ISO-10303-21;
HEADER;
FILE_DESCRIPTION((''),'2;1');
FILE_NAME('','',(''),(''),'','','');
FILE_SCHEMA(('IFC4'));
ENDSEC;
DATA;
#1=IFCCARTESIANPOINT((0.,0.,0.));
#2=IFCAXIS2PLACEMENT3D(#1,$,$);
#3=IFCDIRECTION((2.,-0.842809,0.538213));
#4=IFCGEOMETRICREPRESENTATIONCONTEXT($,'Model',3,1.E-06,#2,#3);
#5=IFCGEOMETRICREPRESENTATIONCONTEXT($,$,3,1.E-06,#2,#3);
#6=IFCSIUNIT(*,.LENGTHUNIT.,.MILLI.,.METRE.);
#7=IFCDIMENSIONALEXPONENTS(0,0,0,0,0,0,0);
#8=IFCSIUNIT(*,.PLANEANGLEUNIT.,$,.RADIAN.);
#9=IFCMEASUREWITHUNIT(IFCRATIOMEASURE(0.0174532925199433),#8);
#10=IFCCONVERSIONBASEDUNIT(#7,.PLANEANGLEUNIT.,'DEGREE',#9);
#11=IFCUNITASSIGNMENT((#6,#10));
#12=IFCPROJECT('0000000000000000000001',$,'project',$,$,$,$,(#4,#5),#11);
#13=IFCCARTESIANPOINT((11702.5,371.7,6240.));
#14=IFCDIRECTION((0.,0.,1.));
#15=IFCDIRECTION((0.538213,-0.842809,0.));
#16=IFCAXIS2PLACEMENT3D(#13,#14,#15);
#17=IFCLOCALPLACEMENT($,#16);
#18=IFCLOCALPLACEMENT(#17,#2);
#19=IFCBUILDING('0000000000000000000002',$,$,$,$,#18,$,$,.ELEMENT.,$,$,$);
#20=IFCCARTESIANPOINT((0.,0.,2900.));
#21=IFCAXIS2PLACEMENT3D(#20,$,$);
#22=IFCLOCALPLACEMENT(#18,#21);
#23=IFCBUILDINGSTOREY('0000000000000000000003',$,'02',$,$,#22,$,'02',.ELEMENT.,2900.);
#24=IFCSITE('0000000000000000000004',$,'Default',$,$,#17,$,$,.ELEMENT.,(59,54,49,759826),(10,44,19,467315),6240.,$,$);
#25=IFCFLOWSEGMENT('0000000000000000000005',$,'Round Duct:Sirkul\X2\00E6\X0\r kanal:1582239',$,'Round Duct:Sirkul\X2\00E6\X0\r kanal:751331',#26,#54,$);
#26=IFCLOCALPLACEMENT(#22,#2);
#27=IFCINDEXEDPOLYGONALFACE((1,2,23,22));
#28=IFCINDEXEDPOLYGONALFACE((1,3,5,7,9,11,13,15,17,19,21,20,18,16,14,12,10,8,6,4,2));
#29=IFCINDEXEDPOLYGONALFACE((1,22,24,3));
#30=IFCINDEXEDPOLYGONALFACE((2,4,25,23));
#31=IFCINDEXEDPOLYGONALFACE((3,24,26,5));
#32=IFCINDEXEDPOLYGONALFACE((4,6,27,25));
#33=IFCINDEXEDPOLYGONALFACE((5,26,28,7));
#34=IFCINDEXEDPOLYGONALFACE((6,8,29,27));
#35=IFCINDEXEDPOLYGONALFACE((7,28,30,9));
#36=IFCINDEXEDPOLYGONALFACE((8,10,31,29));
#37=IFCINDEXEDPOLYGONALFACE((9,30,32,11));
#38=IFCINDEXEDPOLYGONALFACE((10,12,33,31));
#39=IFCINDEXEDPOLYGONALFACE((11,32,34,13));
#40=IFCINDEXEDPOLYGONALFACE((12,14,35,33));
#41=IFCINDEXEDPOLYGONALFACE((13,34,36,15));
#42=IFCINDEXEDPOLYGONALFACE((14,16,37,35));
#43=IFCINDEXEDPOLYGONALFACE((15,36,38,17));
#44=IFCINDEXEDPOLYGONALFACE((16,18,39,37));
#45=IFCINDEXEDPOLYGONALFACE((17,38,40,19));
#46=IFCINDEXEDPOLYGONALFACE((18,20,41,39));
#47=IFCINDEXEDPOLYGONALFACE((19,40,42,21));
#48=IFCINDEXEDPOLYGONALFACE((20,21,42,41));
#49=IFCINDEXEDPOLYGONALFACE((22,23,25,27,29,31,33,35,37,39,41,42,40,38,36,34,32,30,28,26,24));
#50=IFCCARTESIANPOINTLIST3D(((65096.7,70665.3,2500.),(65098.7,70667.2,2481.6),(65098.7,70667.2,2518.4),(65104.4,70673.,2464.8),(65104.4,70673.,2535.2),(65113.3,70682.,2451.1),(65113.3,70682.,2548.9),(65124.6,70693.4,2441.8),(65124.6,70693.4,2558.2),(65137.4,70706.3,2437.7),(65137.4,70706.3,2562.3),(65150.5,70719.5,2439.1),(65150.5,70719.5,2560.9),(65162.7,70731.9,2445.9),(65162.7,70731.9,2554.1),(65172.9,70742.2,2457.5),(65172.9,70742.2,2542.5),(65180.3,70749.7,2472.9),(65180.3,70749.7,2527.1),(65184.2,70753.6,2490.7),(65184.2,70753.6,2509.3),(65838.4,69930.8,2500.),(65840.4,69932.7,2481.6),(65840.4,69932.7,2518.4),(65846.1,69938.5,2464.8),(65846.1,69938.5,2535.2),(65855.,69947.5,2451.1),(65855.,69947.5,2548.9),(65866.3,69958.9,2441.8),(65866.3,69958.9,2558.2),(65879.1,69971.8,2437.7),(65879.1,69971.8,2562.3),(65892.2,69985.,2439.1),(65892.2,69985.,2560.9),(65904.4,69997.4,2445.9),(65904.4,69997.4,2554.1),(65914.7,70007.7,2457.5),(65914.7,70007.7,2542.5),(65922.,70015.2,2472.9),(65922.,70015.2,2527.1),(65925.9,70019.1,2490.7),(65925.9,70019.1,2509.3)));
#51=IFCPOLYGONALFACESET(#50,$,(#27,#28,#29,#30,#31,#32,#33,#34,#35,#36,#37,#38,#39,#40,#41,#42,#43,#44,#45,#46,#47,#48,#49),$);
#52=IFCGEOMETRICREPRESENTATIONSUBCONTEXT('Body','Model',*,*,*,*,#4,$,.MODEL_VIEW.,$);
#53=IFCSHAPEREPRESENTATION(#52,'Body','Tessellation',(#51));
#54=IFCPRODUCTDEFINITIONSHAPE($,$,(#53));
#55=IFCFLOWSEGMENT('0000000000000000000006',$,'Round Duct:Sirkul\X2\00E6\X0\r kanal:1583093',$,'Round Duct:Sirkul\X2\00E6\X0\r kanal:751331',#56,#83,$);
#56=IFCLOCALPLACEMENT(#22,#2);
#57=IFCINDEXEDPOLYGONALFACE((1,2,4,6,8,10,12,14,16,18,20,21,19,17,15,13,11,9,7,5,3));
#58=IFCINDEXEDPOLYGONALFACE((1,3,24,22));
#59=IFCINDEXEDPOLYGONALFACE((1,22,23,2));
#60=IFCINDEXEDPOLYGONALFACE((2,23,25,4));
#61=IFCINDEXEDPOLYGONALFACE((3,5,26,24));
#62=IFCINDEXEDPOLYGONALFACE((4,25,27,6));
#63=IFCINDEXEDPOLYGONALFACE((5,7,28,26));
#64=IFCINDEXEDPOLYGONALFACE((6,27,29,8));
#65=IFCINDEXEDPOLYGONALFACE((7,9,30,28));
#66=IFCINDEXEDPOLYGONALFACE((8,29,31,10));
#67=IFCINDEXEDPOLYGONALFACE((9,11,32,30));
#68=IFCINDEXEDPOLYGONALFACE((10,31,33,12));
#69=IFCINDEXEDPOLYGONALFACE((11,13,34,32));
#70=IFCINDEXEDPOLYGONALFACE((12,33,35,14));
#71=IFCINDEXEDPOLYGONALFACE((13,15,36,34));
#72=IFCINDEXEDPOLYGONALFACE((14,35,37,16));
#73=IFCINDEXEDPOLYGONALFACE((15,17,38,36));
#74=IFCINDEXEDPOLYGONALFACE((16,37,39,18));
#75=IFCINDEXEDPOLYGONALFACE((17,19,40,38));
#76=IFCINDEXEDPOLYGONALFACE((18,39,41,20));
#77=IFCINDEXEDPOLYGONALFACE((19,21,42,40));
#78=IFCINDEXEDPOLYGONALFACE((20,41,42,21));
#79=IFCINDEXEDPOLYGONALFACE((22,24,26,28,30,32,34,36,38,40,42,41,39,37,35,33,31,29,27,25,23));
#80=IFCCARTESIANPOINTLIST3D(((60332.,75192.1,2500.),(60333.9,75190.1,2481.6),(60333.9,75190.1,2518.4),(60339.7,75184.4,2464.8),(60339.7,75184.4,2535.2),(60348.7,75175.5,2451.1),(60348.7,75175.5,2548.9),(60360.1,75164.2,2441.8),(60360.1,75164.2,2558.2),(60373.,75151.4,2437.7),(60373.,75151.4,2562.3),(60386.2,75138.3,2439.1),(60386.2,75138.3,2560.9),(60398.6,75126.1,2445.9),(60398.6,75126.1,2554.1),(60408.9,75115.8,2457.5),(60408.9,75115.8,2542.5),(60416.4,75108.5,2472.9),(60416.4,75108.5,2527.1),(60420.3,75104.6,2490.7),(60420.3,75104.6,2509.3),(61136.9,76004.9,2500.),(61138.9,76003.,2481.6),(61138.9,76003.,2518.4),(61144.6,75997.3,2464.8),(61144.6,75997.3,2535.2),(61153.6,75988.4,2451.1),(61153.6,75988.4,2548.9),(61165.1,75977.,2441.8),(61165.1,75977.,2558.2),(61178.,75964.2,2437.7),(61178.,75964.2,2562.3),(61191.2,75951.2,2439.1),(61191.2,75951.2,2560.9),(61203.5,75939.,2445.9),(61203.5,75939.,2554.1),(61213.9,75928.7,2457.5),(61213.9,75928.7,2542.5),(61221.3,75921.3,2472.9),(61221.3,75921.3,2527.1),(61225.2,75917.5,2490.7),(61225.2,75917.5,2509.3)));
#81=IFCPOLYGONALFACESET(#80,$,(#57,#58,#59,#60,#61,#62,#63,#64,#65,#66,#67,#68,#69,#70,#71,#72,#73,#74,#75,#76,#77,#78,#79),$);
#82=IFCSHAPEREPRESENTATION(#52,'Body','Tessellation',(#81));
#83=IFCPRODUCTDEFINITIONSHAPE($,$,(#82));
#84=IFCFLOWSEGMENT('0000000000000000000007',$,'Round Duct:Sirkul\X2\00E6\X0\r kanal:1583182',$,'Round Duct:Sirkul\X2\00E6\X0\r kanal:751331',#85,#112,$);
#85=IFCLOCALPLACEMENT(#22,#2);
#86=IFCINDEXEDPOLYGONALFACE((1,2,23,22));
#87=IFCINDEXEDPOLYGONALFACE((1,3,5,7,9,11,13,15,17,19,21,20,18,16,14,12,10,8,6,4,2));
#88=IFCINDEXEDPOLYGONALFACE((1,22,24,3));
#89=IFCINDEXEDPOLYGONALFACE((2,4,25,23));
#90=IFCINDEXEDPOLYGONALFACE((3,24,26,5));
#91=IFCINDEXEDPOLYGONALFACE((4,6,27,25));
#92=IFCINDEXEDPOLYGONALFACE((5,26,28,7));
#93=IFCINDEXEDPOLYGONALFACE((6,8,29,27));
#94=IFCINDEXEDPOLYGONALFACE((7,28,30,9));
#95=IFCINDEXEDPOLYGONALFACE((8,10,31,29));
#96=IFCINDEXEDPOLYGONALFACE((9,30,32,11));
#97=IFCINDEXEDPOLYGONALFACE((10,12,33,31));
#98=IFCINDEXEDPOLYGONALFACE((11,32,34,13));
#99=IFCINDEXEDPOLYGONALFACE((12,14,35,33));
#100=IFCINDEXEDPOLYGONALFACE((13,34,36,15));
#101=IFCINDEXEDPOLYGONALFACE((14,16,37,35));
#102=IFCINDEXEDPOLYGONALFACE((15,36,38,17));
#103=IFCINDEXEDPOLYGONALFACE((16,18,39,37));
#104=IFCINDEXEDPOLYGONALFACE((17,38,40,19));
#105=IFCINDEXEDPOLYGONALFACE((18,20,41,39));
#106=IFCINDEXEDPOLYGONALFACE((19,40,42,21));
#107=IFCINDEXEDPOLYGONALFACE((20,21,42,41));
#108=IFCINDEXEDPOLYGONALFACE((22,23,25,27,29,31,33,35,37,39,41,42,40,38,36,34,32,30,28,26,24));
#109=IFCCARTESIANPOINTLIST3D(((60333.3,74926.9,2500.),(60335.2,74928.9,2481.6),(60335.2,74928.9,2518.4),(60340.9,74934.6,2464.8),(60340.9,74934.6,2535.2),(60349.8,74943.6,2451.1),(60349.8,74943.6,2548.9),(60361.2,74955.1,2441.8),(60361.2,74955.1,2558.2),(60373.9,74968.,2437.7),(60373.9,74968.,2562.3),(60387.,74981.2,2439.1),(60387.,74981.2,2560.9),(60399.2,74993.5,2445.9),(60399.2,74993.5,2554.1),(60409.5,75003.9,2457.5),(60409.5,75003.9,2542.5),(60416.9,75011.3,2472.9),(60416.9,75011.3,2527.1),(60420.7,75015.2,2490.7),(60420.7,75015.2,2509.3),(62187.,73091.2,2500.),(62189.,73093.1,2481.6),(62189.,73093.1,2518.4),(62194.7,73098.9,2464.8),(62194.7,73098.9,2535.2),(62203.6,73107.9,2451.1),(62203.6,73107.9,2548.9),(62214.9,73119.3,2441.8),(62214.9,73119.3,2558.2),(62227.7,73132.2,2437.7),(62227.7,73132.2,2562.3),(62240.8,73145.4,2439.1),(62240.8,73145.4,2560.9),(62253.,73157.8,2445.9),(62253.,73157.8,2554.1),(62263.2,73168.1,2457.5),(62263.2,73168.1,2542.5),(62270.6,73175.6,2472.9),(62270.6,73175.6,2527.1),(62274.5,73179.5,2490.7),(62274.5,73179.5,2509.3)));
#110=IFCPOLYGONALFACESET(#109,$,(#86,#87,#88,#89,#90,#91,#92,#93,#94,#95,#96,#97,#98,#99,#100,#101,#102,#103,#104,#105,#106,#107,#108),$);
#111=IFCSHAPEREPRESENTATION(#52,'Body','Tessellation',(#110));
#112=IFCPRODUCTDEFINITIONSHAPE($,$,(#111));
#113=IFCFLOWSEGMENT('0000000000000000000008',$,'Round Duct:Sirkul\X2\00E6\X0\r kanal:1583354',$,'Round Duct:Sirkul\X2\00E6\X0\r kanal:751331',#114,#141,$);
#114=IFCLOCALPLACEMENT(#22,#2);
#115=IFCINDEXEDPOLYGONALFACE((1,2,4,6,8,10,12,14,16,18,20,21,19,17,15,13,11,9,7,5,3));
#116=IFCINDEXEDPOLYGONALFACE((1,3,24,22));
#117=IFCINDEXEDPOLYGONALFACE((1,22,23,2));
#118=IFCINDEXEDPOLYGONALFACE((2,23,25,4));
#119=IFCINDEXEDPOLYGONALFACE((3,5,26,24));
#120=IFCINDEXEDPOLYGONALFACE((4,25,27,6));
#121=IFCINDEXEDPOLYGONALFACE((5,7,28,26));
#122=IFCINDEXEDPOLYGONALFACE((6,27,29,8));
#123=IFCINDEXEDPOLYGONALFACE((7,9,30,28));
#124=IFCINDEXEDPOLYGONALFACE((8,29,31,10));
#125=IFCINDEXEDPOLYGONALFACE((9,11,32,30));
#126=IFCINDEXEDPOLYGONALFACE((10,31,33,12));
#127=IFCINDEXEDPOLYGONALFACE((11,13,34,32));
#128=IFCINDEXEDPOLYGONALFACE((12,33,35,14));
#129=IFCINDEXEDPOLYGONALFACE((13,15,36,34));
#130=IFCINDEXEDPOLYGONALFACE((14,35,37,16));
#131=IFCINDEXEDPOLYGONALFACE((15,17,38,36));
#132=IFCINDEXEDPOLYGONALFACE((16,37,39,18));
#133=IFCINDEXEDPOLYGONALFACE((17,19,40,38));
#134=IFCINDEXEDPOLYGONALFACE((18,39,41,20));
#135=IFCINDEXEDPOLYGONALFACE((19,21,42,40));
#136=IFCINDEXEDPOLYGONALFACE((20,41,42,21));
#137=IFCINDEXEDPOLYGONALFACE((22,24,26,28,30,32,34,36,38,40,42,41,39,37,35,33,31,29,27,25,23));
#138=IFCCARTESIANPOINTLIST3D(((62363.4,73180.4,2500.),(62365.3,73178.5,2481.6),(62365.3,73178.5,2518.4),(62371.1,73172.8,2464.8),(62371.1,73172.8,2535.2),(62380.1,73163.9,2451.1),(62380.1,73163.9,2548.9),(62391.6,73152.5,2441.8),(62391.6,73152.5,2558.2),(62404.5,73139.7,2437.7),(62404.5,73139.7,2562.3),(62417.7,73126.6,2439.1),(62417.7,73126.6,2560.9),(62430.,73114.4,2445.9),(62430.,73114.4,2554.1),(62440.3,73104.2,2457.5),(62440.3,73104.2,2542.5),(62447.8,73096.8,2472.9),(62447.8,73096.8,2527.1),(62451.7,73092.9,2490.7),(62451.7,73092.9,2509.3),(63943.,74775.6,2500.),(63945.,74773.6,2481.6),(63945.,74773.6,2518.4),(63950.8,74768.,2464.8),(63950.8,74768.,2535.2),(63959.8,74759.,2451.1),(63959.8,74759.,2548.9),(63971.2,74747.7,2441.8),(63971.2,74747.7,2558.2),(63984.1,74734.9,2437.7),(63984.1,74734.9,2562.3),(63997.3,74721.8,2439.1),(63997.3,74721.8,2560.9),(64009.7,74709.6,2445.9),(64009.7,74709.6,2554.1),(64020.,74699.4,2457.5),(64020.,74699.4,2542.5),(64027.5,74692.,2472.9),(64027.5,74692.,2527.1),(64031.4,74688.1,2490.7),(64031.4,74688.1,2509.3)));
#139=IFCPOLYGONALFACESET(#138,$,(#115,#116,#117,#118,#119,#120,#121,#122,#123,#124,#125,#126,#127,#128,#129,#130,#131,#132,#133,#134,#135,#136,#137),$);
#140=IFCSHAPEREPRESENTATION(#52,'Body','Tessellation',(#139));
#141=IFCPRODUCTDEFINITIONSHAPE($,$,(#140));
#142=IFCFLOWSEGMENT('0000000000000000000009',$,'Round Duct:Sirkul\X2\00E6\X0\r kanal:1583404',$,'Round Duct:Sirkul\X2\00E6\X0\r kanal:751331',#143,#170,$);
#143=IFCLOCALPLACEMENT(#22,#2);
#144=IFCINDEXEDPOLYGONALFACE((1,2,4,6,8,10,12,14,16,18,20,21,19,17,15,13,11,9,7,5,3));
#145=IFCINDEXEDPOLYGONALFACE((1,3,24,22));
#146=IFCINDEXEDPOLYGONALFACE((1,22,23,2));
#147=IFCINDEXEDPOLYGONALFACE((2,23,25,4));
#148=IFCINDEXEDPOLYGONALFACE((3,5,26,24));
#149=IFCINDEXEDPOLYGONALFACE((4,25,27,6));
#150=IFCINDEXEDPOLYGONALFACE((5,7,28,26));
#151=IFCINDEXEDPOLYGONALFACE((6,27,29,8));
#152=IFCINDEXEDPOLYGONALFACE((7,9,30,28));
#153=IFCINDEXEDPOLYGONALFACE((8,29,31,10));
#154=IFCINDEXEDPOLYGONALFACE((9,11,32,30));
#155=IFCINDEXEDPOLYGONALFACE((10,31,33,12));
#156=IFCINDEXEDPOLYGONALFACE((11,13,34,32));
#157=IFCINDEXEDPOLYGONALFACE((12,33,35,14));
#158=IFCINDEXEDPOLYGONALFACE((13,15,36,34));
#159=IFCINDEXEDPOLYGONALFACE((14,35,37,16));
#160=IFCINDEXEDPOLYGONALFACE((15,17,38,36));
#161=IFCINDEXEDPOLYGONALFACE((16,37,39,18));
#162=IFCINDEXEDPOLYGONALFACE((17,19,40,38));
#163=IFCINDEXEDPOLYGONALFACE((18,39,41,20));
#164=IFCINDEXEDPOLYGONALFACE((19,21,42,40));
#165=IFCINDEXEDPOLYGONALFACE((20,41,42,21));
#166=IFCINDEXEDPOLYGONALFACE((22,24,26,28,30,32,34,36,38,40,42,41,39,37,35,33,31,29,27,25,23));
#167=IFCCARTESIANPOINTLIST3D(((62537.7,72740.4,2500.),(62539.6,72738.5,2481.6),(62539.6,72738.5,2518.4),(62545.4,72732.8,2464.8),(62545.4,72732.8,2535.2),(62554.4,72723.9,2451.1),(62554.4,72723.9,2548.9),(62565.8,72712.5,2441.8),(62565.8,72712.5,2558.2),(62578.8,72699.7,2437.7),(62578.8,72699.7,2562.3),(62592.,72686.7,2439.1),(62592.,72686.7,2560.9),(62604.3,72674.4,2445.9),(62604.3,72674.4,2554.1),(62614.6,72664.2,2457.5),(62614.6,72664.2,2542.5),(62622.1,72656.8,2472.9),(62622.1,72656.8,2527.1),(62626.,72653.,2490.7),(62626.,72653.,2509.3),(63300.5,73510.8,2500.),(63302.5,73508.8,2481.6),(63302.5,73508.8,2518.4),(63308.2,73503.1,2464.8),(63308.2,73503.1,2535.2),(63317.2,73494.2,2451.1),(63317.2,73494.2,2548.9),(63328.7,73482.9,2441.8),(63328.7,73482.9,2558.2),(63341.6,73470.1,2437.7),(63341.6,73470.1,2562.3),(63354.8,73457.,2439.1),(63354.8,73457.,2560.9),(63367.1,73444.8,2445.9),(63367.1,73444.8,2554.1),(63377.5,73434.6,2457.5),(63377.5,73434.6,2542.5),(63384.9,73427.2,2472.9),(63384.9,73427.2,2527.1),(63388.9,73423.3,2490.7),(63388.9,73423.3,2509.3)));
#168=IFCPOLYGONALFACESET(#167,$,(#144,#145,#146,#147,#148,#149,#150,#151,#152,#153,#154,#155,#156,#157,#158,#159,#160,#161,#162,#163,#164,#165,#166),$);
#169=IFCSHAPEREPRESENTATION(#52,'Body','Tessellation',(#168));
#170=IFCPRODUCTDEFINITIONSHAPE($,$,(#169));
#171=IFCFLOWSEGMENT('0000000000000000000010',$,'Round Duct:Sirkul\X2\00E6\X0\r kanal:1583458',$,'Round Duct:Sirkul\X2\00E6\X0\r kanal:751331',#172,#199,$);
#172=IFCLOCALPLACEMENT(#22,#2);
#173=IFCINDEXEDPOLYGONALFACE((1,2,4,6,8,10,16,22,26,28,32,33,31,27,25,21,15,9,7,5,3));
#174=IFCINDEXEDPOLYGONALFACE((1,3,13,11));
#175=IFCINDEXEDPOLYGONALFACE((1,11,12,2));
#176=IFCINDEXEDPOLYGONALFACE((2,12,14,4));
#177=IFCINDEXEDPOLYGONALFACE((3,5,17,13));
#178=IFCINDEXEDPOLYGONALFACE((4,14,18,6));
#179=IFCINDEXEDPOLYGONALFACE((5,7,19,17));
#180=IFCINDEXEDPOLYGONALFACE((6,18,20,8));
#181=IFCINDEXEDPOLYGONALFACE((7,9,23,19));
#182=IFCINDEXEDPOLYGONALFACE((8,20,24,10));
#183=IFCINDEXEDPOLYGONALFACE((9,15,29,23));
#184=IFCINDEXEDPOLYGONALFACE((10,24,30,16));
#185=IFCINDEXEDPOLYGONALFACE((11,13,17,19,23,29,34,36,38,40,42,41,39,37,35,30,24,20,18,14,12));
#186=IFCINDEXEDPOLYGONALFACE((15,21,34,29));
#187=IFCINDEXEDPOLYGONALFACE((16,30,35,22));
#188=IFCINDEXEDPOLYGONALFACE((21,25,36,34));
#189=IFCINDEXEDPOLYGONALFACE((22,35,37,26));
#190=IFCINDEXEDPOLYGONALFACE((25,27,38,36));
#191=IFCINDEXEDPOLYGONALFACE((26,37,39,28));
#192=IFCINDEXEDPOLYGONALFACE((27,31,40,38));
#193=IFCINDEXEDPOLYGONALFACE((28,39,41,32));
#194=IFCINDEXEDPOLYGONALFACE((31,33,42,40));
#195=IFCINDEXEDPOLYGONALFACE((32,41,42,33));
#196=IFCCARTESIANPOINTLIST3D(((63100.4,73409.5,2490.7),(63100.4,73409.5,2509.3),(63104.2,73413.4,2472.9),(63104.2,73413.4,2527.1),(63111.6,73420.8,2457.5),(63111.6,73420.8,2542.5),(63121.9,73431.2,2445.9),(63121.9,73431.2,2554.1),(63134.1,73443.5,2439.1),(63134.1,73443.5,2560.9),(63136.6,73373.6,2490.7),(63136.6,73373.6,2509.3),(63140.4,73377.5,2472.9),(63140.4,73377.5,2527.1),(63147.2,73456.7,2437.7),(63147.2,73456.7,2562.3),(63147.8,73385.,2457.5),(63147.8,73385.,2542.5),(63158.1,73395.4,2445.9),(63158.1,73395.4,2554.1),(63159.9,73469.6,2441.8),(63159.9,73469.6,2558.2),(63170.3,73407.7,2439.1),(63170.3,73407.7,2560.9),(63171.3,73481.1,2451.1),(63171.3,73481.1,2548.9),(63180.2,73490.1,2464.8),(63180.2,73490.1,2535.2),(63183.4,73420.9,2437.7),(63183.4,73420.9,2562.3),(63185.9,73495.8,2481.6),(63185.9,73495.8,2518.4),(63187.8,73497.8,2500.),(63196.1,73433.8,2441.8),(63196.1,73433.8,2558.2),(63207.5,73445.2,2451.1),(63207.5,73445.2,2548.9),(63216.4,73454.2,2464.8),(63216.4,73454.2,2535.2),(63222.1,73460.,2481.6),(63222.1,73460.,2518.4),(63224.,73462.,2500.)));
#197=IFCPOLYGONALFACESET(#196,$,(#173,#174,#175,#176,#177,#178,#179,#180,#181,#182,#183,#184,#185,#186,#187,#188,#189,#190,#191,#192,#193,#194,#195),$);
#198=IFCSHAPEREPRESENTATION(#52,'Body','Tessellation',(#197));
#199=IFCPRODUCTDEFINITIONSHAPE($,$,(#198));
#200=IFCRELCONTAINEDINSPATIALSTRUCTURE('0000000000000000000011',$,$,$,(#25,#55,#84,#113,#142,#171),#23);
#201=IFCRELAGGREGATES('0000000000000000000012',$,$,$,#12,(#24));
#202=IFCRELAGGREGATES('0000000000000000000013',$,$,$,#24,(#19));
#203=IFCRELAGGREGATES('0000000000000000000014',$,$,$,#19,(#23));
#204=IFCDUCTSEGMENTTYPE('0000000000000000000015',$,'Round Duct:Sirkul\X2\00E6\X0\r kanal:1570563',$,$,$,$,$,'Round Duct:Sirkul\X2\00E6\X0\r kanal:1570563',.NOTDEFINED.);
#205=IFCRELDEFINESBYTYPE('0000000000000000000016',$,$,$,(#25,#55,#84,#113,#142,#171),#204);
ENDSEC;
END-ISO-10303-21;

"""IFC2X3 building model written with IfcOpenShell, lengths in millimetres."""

from ifc_helpers import new_model, entity, si_unit, converted_unit, direction, frame, origin, origin_2d_with_axis, place, context, subcontext, project, spatial, circle, extrude, type_object, element, save


model = new_model("IFC2X3")

# Units and contexts
model_context = context("Model", 3, precision=1e-06, world=origin(), true_north=direction((2.0, -0.842809, 0.538213)))
context_of_model = context(None, 3, precision=1e-06, world=origin(), true_north=direction((2.0, -0.842809, 0.538213)))
body_context = subcontext(model_context, "Body", "Model", "MODEL_VIEW")
ifc_project = project(units=[si_unit("LENGTHUNIT", "METRE", prefix="MILLI"), converted_unit("PLANEANGLEUNIT", "DEGREE", entity("IfcRatioMeasure", 0.0174532925199433), si_unit("PLANEANGLEUNIT", "RADIAN"), dimensions=[0, 0, 0, 0, 0, 0, 0])], contexts=[model_context, context_of_model])

# Site, building, storey
site_placement = place(None, frame((11702.5, 371.7, 6240.0), z_axis=(0.0, 0.0, 1.0), x_axis=(0.538213, -0.842809, 0.0)))
site = spatial("IfcSite", under=ifc_project, at=site_placement, Name="Default", CompositionType="ELEMENT", RefLatitude=(59, 54, 49, 759826), RefLongitude=(10, 44, 19, 467315), RefElevation=6240.0)
building_placement = place(site_placement, origin())
building = spatial("IfcBuilding", under=site, at=building_placement, CompositionType="ELEMENT")
storey_placement = place(building_placement, frame((0.0, 0.0, 2900.0)))
storey = spatial("IfcBuildingStorey", under=building, at=storey_placement, Name="02", LongName="02", CompositionType="ELEMENT", Elevation=2900.0)

# Flow segments
duct_segment_type = type_object("IfcDuctSegmentType", Name="Round Duct:Sirkulær kanal:1570563", ElementType="Round Duct:Sirkulær kanal:1570563", PredefinedType="NOTDEFINED")
flow_segment_1_placement = place(storey_placement, origin())
element("IfcFlowSegment", 1, at=flow_segment_1_placement, inside=storey, type_object=duct_segment_type, Name="Round Duct:Sirkulær kanal:1582239", ObjectType="Round Duct:Sirkulær kanal:751331", context=body_context, shape_type="SweptSolid", body=[
    extrude(circle(Radius=62.5, at=origin_2d_with_axis()), frame((65140.7, 70709.7, 2500.0), z_axis=(0.710554, -0.703643, 0.0), x_axis=(-0.703643, -0.710554, 0.0)), (0.0, 0.0, 1.0), 1043.9),
])
flow_segment_2_placement = place(storey_placement, origin())
element("IfcFlowSegment", 2, at=flow_segment_2_placement, inside=storey, type_object=duct_segment_type, Name="Round Duct:Sirkulær kanal:1583093", ObjectType="Round Duct:Sirkulær kanal:751331", context=body_context, shape_type="SweptSolid", body=[
    extrude(circle(Radius=62.5, at=origin_2d_with_axis()), frame((60376.4, 75148.1, 2500.0), z_axis=(0.703643, 0.710554, 0.0), x_axis=(-0.710554, 0.703643, 0.0)), (0.0, 0.0, 1.0), 1144.0),
])
flow_segment_3_placement = place(storey_placement, origin())
element("IfcFlowSegment", 3, at=flow_segment_3_placement, inside=storey, type_object=duct_segment_type, Name="Round Duct:Sirkulær kanal:1583182", ObjectType="Round Duct:Sirkulær kanal:751331", context=body_context, shape_type="SweptSolid", body=[
    extrude(circle(Radius=62.5, at=origin_2d_with_axis()), frame((62231.0, 73135.6, 2500.0), z_axis=(-0.710554, 0.703643, 0.0), x_axis=(-0.703643, -0.710554, 0.0)), (0.0, 0.0, 1.0), 2608.9),
])
flow_segment_4_placement = place(storey_placement, origin())
element("IfcFlowSegment", 4, at=flow_segment_4_placement, inside=storey, type_object=duct_segment_type, Name="Round Duct:Sirkulær kanal:1583354", ObjectType="Round Duct:Sirkulær kanal:751331", context=body_context, shape_type="SweptSolid", body=[
    extrude(circle(Radius=62.5, at=origin_2d_with_axis()), frame((62407.8, 73136.4, 2500.0), z_axis=(0.703643, 0.710554, 0.0), x_axis=(-0.710554, 0.703643, 0.0)), (0.0, 0.0, 1.0), 2245.0),
])
flow_segment_5_placement = place(storey_placement, origin())
element("IfcFlowSegment", 5, at=flow_segment_5_placement, inside=storey, type_object=duct_segment_type, Name="Round Duct:Sirkulær kanal:1583404", ObjectType="Round Duct:Sirkulær kanal:751331", context=body_context, shape_type="SweptSolid", body=[
    extrude(circle(Radius=62.5, at=origin_2d_with_axis()), frame((62582.1, 72696.4, 2500.0), z_axis=(0.703643, 0.710554, 0.0), x_axis=(-0.710554, 0.703643, 0.0)), (0.0, 0.0, 1.0), 1084.2),
])
flow_segment_6_placement = place(storey_placement, origin())
element("IfcFlowSegment", 6, at=flow_segment_6_placement, inside=storey, type_object=duct_segment_type, Name="Round Duct:Sirkulær kanal:1583458", ObjectType="Round Duct:Sirkulær kanal:751331", context=body_context, shape_type="SweptSolid", body=[
    extrude(circle(Radius=62.5, at=origin_2d_with_axis()), frame((63143.9, 73453.4, 2500.0), z_axis=(0.710554, -0.703643, 0.0), x_axis=(0.703643, 0.710554, 0.0)), (0.0, 0.0, 1.0), 50.9),
])

save(model, "model.ifc")
